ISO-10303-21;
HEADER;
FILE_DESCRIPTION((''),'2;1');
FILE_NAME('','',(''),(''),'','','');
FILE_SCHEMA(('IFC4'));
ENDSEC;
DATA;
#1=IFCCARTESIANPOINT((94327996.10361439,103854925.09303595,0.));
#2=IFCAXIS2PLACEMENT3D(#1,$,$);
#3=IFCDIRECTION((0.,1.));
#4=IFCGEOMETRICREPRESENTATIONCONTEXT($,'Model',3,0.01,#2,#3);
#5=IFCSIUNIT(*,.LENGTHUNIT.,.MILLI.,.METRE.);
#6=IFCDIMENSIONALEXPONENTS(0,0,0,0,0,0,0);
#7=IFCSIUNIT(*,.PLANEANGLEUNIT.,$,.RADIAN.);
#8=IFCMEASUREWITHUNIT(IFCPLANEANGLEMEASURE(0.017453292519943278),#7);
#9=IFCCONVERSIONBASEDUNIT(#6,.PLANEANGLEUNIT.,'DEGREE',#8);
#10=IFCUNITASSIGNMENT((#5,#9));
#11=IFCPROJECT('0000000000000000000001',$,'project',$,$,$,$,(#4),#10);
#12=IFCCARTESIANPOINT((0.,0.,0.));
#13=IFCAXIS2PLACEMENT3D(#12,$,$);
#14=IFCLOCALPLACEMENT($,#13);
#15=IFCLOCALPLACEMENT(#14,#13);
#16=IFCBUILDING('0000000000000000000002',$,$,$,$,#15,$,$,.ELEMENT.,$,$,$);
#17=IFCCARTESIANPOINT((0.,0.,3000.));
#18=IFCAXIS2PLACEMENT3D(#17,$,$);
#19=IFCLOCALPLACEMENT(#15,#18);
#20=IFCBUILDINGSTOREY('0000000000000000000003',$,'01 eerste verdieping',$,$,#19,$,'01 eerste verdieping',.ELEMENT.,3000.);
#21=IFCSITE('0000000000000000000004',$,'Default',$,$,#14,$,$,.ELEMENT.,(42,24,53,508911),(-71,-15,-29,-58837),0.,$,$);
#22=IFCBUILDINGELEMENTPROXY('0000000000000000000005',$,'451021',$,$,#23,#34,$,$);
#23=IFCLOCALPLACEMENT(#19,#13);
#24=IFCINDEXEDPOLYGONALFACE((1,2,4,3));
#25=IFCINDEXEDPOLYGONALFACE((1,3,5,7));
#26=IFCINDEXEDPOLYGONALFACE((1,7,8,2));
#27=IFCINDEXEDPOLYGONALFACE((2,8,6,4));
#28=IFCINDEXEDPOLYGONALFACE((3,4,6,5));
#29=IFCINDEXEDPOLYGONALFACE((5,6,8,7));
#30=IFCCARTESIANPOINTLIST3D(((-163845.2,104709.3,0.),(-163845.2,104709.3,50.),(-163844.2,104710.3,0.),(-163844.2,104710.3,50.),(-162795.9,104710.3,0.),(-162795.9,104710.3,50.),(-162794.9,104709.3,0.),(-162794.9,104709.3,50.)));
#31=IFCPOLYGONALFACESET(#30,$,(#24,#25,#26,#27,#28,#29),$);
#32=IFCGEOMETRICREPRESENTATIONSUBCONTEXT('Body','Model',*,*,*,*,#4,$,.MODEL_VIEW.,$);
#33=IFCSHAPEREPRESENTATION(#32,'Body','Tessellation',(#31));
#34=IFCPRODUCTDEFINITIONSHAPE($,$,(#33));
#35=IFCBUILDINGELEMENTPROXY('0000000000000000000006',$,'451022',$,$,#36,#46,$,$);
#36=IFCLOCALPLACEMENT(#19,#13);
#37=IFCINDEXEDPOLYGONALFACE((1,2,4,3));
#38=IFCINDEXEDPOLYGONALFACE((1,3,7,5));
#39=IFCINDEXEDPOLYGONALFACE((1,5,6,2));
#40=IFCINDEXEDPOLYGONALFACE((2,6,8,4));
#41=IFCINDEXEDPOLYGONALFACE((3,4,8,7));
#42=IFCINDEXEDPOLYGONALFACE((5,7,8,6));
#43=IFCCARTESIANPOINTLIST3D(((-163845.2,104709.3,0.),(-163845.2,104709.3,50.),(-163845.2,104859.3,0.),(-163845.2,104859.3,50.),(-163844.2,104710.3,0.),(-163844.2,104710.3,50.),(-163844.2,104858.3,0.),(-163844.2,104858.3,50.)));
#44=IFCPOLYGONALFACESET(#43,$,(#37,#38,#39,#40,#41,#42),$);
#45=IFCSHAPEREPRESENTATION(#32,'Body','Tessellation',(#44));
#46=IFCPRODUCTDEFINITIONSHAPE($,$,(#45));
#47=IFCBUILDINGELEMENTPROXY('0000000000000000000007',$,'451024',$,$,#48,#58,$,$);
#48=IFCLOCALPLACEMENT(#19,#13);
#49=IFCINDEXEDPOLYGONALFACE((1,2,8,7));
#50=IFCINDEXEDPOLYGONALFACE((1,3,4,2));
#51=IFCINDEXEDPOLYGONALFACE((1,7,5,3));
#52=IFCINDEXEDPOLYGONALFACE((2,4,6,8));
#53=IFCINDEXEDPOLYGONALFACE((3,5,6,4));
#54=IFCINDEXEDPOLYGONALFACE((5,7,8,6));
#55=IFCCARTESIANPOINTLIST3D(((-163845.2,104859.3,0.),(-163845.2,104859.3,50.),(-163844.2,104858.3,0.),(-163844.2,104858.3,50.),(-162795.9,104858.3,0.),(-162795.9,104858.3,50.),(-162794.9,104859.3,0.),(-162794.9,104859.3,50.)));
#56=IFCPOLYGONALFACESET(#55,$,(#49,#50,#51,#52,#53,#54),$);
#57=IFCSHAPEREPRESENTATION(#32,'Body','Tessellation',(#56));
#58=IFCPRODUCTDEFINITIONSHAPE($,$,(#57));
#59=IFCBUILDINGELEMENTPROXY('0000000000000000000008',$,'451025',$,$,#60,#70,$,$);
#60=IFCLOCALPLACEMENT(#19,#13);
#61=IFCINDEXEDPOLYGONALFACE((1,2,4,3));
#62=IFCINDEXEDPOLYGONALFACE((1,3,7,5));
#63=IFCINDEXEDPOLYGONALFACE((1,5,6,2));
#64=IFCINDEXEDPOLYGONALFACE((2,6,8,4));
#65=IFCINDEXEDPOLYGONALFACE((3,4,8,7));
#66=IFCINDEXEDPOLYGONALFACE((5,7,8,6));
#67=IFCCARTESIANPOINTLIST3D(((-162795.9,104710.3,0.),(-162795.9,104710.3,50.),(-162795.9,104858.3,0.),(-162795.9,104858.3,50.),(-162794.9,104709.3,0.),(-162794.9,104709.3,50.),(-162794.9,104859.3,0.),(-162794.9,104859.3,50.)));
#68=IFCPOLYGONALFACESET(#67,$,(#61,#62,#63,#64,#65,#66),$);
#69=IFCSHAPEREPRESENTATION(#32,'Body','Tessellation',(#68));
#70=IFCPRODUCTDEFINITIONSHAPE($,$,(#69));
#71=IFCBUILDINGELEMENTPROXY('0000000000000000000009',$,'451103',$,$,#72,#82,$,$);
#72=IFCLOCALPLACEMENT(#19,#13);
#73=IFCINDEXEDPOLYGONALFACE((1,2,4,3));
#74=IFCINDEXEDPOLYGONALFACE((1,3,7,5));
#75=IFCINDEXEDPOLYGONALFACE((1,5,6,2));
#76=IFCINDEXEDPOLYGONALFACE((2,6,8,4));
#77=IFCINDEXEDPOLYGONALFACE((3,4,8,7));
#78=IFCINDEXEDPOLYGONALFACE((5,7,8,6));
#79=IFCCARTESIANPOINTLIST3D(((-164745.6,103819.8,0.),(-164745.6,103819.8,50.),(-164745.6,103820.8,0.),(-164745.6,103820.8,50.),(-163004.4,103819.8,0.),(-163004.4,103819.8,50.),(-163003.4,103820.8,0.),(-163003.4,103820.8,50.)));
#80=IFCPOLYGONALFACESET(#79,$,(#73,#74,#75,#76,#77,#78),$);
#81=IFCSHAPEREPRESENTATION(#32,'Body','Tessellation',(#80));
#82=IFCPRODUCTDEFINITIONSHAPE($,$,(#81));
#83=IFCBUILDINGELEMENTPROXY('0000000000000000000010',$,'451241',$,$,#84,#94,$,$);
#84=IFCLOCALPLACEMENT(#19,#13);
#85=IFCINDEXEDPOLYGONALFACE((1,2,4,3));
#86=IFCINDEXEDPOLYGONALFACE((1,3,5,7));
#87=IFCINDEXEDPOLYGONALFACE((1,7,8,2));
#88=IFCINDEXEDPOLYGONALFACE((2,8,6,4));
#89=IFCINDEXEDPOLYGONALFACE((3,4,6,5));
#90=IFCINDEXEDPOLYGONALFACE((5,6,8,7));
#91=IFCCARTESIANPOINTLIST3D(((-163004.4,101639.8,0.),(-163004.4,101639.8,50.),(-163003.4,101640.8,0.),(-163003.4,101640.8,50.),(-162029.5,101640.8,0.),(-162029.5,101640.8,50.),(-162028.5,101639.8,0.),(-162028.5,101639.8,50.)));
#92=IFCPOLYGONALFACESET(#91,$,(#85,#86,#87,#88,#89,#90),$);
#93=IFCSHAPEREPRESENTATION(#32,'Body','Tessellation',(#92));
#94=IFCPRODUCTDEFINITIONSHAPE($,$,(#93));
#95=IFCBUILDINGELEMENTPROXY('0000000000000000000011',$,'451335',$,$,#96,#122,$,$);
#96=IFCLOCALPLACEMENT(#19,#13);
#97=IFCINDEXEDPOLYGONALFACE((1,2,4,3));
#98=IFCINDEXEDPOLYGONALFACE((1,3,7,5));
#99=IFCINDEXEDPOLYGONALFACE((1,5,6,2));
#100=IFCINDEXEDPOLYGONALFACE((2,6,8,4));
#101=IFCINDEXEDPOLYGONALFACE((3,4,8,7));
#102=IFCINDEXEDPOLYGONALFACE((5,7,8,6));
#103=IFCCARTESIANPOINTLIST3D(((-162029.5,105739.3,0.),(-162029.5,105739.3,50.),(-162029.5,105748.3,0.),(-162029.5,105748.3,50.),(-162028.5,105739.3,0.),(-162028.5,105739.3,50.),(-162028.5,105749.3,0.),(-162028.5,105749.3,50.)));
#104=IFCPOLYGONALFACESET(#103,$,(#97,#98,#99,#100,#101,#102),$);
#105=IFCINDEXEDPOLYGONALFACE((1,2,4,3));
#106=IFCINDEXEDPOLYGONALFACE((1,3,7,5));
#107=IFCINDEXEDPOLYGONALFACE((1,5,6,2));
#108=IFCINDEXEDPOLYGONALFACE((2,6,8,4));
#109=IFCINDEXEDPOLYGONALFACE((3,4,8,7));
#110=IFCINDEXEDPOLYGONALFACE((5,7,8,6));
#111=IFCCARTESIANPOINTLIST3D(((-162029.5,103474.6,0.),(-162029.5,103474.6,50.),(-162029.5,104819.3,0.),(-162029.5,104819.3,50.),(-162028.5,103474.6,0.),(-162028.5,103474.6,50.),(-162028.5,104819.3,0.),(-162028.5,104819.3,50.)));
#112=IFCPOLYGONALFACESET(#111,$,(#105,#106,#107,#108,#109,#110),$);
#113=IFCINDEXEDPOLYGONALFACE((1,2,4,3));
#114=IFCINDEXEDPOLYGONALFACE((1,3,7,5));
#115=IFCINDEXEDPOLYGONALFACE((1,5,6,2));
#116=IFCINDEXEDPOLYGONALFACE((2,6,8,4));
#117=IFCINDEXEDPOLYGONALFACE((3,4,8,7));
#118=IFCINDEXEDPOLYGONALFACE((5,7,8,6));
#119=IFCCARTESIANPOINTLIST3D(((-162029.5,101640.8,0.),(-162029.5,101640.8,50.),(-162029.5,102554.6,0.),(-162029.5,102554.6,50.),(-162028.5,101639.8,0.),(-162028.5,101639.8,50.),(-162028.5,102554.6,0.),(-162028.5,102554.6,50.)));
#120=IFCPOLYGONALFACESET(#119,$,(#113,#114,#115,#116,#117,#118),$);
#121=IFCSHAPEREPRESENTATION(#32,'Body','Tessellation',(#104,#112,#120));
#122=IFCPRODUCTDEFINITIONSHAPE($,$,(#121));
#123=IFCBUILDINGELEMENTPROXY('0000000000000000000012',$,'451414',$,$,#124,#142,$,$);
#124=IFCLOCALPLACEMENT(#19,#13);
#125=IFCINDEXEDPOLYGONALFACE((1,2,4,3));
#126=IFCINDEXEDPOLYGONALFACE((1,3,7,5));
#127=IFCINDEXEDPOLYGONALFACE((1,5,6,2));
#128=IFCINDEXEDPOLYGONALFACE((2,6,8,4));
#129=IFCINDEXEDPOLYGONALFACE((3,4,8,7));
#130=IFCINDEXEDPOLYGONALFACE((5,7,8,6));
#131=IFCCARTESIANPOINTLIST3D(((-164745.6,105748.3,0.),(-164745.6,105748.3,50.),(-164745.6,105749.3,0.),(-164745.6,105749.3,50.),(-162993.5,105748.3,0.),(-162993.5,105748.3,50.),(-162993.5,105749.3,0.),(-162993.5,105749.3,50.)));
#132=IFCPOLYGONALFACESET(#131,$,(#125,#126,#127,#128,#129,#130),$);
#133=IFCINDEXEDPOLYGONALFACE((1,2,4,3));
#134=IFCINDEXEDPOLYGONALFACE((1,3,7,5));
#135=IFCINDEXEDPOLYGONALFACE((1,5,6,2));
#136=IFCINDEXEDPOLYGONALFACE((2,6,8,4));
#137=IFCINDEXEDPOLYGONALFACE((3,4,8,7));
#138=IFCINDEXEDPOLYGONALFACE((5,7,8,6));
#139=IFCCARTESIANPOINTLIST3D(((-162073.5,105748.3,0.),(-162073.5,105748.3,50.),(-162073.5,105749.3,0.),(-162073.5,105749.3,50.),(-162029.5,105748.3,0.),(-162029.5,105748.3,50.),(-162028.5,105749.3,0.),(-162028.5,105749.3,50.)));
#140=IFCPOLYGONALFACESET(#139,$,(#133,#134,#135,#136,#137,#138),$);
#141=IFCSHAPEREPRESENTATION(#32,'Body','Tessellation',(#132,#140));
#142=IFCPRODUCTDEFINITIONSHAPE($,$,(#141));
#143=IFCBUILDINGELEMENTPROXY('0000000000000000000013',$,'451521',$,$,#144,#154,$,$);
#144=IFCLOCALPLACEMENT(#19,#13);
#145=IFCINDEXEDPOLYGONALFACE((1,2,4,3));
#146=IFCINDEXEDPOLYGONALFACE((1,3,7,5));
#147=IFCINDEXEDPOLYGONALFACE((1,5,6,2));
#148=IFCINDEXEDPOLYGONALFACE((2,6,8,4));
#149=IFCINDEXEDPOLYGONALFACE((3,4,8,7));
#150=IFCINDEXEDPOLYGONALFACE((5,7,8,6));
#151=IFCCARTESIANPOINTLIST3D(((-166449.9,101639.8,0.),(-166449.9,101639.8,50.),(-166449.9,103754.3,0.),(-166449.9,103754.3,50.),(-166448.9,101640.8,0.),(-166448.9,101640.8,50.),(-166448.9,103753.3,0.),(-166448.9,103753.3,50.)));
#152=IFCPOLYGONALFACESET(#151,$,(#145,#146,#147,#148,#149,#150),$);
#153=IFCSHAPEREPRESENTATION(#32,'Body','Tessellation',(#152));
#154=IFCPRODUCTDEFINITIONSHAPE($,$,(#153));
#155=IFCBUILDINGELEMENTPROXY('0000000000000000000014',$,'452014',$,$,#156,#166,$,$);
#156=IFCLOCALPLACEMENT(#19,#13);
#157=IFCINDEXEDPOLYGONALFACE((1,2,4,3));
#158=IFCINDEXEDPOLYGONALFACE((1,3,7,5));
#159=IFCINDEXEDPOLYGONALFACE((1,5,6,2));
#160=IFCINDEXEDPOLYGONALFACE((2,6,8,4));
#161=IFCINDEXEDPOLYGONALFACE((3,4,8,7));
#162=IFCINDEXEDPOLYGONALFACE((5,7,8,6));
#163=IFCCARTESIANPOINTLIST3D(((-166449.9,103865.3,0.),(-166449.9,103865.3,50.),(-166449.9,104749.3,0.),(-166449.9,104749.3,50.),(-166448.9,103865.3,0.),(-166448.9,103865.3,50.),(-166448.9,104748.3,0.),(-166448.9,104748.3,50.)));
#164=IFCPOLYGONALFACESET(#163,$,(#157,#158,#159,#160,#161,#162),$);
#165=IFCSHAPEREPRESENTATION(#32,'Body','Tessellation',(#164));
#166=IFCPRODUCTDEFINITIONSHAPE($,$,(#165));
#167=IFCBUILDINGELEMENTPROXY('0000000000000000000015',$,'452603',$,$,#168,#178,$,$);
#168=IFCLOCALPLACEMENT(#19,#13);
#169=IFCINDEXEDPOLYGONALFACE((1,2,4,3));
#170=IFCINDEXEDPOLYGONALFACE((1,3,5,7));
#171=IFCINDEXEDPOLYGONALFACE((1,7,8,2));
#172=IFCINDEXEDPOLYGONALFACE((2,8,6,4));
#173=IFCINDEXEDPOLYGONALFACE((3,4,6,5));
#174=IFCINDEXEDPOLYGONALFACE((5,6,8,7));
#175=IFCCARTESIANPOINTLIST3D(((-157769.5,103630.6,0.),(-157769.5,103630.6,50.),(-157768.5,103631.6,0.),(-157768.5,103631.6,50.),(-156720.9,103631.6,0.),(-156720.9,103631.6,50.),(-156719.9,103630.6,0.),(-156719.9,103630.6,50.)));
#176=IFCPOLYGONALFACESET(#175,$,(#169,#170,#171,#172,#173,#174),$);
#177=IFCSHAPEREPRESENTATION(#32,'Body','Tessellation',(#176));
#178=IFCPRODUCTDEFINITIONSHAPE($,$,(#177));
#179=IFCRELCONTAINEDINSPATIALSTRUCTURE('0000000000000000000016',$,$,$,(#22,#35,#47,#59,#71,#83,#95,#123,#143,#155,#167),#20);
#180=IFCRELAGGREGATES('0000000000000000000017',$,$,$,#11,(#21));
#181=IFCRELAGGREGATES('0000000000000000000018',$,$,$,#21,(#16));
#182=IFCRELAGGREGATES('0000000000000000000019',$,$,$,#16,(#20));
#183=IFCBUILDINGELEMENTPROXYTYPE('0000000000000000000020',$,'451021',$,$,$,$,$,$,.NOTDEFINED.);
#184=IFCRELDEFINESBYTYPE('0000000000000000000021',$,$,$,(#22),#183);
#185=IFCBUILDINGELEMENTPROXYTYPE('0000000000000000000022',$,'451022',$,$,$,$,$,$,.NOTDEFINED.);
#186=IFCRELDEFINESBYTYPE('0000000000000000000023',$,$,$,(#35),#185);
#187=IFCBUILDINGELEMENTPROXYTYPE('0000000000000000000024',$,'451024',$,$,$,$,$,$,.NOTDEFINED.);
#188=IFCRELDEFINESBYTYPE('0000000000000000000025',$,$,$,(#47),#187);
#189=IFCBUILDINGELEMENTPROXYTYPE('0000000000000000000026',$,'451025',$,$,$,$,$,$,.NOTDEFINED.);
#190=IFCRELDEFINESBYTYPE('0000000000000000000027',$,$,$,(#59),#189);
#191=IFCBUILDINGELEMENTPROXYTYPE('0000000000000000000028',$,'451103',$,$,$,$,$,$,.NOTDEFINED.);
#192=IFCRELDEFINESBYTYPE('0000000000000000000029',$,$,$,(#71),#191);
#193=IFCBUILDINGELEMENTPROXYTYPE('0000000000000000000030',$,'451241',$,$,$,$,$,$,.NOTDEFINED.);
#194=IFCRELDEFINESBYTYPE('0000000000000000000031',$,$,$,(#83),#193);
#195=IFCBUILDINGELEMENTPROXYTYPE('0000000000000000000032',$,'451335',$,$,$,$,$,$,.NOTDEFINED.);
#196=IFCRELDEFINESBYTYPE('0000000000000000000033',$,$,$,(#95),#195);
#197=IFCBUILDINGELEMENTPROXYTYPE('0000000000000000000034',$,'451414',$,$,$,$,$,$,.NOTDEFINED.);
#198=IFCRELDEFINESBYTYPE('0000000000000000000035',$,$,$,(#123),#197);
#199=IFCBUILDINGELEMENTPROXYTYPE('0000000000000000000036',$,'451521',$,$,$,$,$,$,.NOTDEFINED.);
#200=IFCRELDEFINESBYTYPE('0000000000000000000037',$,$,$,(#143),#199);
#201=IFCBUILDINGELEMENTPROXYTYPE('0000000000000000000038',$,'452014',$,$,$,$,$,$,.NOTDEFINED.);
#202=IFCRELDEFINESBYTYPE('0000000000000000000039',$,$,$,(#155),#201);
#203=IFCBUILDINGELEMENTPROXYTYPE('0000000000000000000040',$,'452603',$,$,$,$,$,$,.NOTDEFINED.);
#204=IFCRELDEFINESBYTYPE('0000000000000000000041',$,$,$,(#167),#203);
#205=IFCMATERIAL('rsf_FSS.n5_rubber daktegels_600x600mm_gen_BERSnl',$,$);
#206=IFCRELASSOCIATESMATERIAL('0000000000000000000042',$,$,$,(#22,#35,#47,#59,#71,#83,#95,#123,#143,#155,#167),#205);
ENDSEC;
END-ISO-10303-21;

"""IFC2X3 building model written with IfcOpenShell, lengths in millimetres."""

from ifc_helpers import new_model, entity, si_unit, converted_unit, direction, frame, frame_2d, origin, place, context, subcontext, project, spatial, polyline, rectangle, outline, extrude, material, type_object, element, save


model = new_model("IFC2X3")

# Units and contexts
model_context = context("Model", 3, precision=0.01, world=frame((94327996.10361439, 103854925.09303595, 0.0)), true_north=direction((0.0, 1.0)))
body_context = subcontext(model_context, "Body", "Model", "MODEL_VIEW")
ifc_project = project(units=[si_unit("LENGTHUNIT", "METRE", prefix="MILLI"), converted_unit("PLANEANGLEUNIT", "DEGREE", entity("IfcPlaneAngleMeasure", 0.017453292519943278), si_unit("PLANEANGLEUNIT", "RADIAN"), dimensions=[0, 0, 0, 0, 0, 0, 0])], contexts=[model_context])

# Site, building, storey
site_placement = place(None, origin())
site = spatial("IfcSite", under=ifc_project, at=site_placement, Name="Default", CompositionType="ELEMENT", RefLatitude=(42, 24, 53, 508911), RefLongitude=(-71, -15, -29, -58837), RefElevation=0.0)
building_placement = place(site_placement, origin())
building = spatial("IfcBuilding", under=site, at=building_placement, CompositionType="ELEMENT")
storey_placement = place(building_placement, frame((0.0, 0.0, 3000.0)))
storey = spatial("IfcBuildingStorey", under=building, at=storey_placement, Name="01 eerste verdieping", LongName="01 eerste verdieping", CompositionType="ELEMENT", Elevation=3000.0)

# Building element proxies
ifc_material = material(Name="rsf_FSS.n5_rubber daktegels_600x600mm_gen_BERSnl")
building_element_proxy_type_1 = type_object("IfcBuildingElementProxyType", Name="451021", PredefinedType="NOTDEFINED")
proxy_1_placement = place(storey_placement, origin())
element("IfcBuildingElementProxy", 1, at=proxy_1_placement, inside=storey, type_object=building_element_proxy_type_1, material=ifc_material, Name="451021", context=body_context, shape_type="SweptSolid", body=[
    extrude(outline(polyline([(-525.2, -0.5), (525.2, -0.5), (524.2, 0.5), (-524.2, 0.5), (-525.2, -0.5)])), frame((-163320.1, 104709.8, 0.0)), (0.0, 0.0, 1.0), 50.0),
])
building_element_proxy_type_2 = type_object("IfcBuildingElementProxyType", Name="451022", PredefinedType="NOTDEFINED")
proxy_2_placement = place(storey_placement, origin())
element("IfcBuildingElementProxy", 2, at=proxy_2_placement, inside=storey, type_object=building_element_proxy_type_2, material=ifc_material, Name="451022", context=body_context, shape_type="SweptSolid", body=[
    extrude(outline(polyline([(-75.0, -0.5), (75.0, -0.5), (74.0, 0.5), (-74.0, 0.5), (-75.0, -0.5)])), frame((-163844.7, 104784.3, 0.0), z_axis=(0.0, 0.0, 1.0), x_axis=(0.0, -1.0, 0.0)), (0.0, 0.0, 1.0), 50.0),
])
building_element_proxy_type_3 = type_object("IfcBuildingElementProxyType", Name="451024", PredefinedType="NOTDEFINED")
proxy_3_placement = place(storey_placement, origin())
element("IfcBuildingElementProxy", 3, at=proxy_3_placement, inside=storey, type_object=building_element_proxy_type_3, material=ifc_material, Name="451024", context=body_context, shape_type="SweptSolid", body=[
    extrude(outline(polyline([(-525.2, -0.5), (525.2, -0.5), (524.2, 0.5), (-524.2, 0.5), (-525.2, -0.5)])), frame((-163320.1, 104858.8, 0.0), z_axis=(0.0, 0.0, 1.0), x_axis=(-1.0, 0.0, 0.0)), (0.0, 0.0, 1.0), 50.0),
])
building_element_proxy_type_4 = type_object("IfcBuildingElementProxyType", Name="451025", PredefinedType="NOTDEFINED")
proxy_4_placement = place(storey_placement, origin())
element("IfcBuildingElementProxy", 4, at=proxy_4_placement, inside=storey, type_object=building_element_proxy_type_4, material=ifc_material, Name="451025", context=body_context, shape_type="SweptSolid", body=[
    extrude(outline(polyline([(-75.0, -0.5), (75.0, -0.5), (74.0, 0.5), (-74.0, 0.5), (-75.0, -0.5)])), frame((-162795.4, 104784.3, 0.0), z_axis=(0.0, 0.0, 1.0), x_axis=(0.0, 1.0, 0.0)), (0.0, 0.0, 1.0), 50.0),
])
building_element_proxy_type_5 = type_object("IfcBuildingElementProxyType", Name="451103", PredefinedType="NOTDEFINED")
proxy_5_placement = place(storey_placement, origin())
element("IfcBuildingElementProxy", 5, at=proxy_5_placement, inside=storey, type_object=building_element_proxy_type_5, material=ifc_material, Name="451103", context=body_context, shape_type="SweptSolid", body=[
    extrude(outline(polyline([(-870.8, -0.5), (870.3, -0.5), (871.3, 0.5), (-870.8, 0.5), (-870.8, -0.5)])), frame((-163874.8, 103820.3, 0.0)), (0.0, 0.0, 1.0), 50.0),
])
building_element_proxy_type_6 = type_object("IfcBuildingElementProxyType", Name="451241", PredefinedType="NOTDEFINED")
proxy_6_placement = place(storey_placement, origin())
element("IfcBuildingElementProxy", 6, at=proxy_6_placement, inside=storey, type_object=building_element_proxy_type_6, material=ifc_material, Name="451241", context=body_context, shape_type="SweptSolid", body=[
    extrude(outline(polyline([(-488.0, -0.5), (488.0, -0.5), (487.0, 0.5), (-487.0, 0.5), (-488.0, -0.5)])), frame((-162516.5, 101640.3, 0.0)), (0.0, 0.0, 1.0), 50.0),
])
building_element_proxy_type_7 = type_object("IfcBuildingElementProxyType", Name="451335", PredefinedType="NOTDEFINED")
proxy_7_placement = place(storey_placement, origin())
element("IfcBuildingElementProxy", 7, at=proxy_7_placement, inside=storey, type_object=building_element_proxy_type_7, material=ifc_material, Name="451335", context=body_context, shape_type="SweptSolid", body=[
    extrude(outline(polyline([(-4.7, -0.5), (5.2, -0.5), (4.2, 0.5), (-4.7, 0.5), (-4.7, -0.5)])), frame((-162029.0, 105744.0, 0.0), z_axis=(0.0, 0.0, 1.0), x_axis=(0.0, 1.0, 0.0)), (0.0, 0.0, 1.0), 50.0),
    extrude(rectangle(XDim=1344.7, YDim=1.0, at=frame_2d((0.0, 0.0), x_axis=(1.0, 0.0))), frame((-162029.0, 104146.9, 0.0), z_axis=(0.0, 0.0, 1.0), x_axis=(0.0, 1.0, 0.0)), (0.0, 0.0, 1.0), 50.0),
    extrude(outline(polyline([(-457.6, -0.5), (457.1, -0.5), (457.1, 0.5), (-456.6, 0.5), (-457.6, -0.5)])), frame((-162029.0, 102097.4, 0.0), z_axis=(0.0, 0.0, 1.0), x_axis=(0.0, 1.0, 0.0)), (0.0, 0.0, 1.0), 50.0),
])
building_element_proxy_type_8 = type_object("IfcBuildingElementProxyType", Name="451414", PredefinedType="NOTDEFINED")
proxy_8_placement = place(storey_placement, origin())
element("IfcBuildingElementProxy", 8, at=proxy_8_placement, inside=storey, type_object=building_element_proxy_type_8, material=ifc_material, Name="451414", context=body_context, shape_type="SweptSolid", body=[
    extrude(rectangle(XDim=1752.1, YDim=1.0, at=frame_2d((0.0, 0.0), x_axis=(1.0, 0.0))), frame((-163869.6, 105748.8, 0.0), z_axis=(0.0, 0.0, 1.0), x_axis=(-1.0, 0.0, 0.0)), (0.0, 0.0, 1.0), 50.0),
    extrude(outline(polyline([(-22.8, -0.5), (22.3, -0.5), (22.3, 0.5), (-21.8, 0.5), (-22.8, -0.5)])), frame((-162051.3, 105748.8, 0.0), z_axis=(0.0, 0.0, 1.0), x_axis=(-1.0, 0.0, 0.0)), (0.0, 0.0, 1.0), 50.0),
])
building_element_proxy_type_9 = type_object("IfcBuildingElementProxyType", Name="451521", PredefinedType="NOTDEFINED")
proxy_9_placement = place(storey_placement, origin())
element("IfcBuildingElementProxy", 9, at=proxy_9_placement, inside=storey, type_object=building_element_proxy_type_9, material=ifc_material, Name="451521", context=body_context, shape_type="SweptSolid", body=[
    extrude(outline(polyline([(-1057.3, -0.5), (1057.3, -0.5), (1056.3, 0.5), (-1056.3, 0.5), (-1057.3, -0.5)])), frame((-166449.4, 102697.0, 0.0), z_axis=(0.0, 0.0, 1.0), x_axis=(0.0, -1.0, 0.0)), (0.0, 0.0, 1.0), 50.0),
])
building_element_proxy_type_10 = type_object("IfcBuildingElementProxyType", Name="452014", PredefinedType="NOTDEFINED")
proxy_10_placement = place(storey_placement, origin())
element("IfcBuildingElementProxy", 10, at=proxy_10_placement, inside=storey, type_object=building_element_proxy_type_10, material=ifc_material, Name="452014", context=body_context, shape_type="SweptSolid", body=[
    extrude(outline(polyline([(-442.3, -0.5), (441.8, -0.5), (441.8, 0.5), (-441.3, 0.5), (-442.3, -0.5)])), frame((-166449.4, 104307.0, 0.0), z_axis=(0.0, 0.0, 1.0), x_axis=(0.0, -1.0, 0.0)), (0.0, 0.0, 1.0), 50.0),
])
building_element_proxy_type_11 = type_object("IfcBuildingElementProxyType", Name="452603", PredefinedType="NOTDEFINED")
proxy_11_placement = place(storey_placement, origin())
element("IfcBuildingElementProxy", 11, at=proxy_11_placement, inside=storey, type_object=building_element_proxy_type_11, material=ifc_material, Name="452603", context=body_context, shape_type="SweptSolid", body=[
    extrude(outline(polyline([(-524.8, -0.5), (524.8, -0.5), (523.8, 0.5), (-523.8, 0.5), (-524.8, -0.5)])), frame((-157244.7, 103631.1, 0.0)), (0.0, 0.0, 1.0), 50.0),
])

save(model, "model.ifc")
